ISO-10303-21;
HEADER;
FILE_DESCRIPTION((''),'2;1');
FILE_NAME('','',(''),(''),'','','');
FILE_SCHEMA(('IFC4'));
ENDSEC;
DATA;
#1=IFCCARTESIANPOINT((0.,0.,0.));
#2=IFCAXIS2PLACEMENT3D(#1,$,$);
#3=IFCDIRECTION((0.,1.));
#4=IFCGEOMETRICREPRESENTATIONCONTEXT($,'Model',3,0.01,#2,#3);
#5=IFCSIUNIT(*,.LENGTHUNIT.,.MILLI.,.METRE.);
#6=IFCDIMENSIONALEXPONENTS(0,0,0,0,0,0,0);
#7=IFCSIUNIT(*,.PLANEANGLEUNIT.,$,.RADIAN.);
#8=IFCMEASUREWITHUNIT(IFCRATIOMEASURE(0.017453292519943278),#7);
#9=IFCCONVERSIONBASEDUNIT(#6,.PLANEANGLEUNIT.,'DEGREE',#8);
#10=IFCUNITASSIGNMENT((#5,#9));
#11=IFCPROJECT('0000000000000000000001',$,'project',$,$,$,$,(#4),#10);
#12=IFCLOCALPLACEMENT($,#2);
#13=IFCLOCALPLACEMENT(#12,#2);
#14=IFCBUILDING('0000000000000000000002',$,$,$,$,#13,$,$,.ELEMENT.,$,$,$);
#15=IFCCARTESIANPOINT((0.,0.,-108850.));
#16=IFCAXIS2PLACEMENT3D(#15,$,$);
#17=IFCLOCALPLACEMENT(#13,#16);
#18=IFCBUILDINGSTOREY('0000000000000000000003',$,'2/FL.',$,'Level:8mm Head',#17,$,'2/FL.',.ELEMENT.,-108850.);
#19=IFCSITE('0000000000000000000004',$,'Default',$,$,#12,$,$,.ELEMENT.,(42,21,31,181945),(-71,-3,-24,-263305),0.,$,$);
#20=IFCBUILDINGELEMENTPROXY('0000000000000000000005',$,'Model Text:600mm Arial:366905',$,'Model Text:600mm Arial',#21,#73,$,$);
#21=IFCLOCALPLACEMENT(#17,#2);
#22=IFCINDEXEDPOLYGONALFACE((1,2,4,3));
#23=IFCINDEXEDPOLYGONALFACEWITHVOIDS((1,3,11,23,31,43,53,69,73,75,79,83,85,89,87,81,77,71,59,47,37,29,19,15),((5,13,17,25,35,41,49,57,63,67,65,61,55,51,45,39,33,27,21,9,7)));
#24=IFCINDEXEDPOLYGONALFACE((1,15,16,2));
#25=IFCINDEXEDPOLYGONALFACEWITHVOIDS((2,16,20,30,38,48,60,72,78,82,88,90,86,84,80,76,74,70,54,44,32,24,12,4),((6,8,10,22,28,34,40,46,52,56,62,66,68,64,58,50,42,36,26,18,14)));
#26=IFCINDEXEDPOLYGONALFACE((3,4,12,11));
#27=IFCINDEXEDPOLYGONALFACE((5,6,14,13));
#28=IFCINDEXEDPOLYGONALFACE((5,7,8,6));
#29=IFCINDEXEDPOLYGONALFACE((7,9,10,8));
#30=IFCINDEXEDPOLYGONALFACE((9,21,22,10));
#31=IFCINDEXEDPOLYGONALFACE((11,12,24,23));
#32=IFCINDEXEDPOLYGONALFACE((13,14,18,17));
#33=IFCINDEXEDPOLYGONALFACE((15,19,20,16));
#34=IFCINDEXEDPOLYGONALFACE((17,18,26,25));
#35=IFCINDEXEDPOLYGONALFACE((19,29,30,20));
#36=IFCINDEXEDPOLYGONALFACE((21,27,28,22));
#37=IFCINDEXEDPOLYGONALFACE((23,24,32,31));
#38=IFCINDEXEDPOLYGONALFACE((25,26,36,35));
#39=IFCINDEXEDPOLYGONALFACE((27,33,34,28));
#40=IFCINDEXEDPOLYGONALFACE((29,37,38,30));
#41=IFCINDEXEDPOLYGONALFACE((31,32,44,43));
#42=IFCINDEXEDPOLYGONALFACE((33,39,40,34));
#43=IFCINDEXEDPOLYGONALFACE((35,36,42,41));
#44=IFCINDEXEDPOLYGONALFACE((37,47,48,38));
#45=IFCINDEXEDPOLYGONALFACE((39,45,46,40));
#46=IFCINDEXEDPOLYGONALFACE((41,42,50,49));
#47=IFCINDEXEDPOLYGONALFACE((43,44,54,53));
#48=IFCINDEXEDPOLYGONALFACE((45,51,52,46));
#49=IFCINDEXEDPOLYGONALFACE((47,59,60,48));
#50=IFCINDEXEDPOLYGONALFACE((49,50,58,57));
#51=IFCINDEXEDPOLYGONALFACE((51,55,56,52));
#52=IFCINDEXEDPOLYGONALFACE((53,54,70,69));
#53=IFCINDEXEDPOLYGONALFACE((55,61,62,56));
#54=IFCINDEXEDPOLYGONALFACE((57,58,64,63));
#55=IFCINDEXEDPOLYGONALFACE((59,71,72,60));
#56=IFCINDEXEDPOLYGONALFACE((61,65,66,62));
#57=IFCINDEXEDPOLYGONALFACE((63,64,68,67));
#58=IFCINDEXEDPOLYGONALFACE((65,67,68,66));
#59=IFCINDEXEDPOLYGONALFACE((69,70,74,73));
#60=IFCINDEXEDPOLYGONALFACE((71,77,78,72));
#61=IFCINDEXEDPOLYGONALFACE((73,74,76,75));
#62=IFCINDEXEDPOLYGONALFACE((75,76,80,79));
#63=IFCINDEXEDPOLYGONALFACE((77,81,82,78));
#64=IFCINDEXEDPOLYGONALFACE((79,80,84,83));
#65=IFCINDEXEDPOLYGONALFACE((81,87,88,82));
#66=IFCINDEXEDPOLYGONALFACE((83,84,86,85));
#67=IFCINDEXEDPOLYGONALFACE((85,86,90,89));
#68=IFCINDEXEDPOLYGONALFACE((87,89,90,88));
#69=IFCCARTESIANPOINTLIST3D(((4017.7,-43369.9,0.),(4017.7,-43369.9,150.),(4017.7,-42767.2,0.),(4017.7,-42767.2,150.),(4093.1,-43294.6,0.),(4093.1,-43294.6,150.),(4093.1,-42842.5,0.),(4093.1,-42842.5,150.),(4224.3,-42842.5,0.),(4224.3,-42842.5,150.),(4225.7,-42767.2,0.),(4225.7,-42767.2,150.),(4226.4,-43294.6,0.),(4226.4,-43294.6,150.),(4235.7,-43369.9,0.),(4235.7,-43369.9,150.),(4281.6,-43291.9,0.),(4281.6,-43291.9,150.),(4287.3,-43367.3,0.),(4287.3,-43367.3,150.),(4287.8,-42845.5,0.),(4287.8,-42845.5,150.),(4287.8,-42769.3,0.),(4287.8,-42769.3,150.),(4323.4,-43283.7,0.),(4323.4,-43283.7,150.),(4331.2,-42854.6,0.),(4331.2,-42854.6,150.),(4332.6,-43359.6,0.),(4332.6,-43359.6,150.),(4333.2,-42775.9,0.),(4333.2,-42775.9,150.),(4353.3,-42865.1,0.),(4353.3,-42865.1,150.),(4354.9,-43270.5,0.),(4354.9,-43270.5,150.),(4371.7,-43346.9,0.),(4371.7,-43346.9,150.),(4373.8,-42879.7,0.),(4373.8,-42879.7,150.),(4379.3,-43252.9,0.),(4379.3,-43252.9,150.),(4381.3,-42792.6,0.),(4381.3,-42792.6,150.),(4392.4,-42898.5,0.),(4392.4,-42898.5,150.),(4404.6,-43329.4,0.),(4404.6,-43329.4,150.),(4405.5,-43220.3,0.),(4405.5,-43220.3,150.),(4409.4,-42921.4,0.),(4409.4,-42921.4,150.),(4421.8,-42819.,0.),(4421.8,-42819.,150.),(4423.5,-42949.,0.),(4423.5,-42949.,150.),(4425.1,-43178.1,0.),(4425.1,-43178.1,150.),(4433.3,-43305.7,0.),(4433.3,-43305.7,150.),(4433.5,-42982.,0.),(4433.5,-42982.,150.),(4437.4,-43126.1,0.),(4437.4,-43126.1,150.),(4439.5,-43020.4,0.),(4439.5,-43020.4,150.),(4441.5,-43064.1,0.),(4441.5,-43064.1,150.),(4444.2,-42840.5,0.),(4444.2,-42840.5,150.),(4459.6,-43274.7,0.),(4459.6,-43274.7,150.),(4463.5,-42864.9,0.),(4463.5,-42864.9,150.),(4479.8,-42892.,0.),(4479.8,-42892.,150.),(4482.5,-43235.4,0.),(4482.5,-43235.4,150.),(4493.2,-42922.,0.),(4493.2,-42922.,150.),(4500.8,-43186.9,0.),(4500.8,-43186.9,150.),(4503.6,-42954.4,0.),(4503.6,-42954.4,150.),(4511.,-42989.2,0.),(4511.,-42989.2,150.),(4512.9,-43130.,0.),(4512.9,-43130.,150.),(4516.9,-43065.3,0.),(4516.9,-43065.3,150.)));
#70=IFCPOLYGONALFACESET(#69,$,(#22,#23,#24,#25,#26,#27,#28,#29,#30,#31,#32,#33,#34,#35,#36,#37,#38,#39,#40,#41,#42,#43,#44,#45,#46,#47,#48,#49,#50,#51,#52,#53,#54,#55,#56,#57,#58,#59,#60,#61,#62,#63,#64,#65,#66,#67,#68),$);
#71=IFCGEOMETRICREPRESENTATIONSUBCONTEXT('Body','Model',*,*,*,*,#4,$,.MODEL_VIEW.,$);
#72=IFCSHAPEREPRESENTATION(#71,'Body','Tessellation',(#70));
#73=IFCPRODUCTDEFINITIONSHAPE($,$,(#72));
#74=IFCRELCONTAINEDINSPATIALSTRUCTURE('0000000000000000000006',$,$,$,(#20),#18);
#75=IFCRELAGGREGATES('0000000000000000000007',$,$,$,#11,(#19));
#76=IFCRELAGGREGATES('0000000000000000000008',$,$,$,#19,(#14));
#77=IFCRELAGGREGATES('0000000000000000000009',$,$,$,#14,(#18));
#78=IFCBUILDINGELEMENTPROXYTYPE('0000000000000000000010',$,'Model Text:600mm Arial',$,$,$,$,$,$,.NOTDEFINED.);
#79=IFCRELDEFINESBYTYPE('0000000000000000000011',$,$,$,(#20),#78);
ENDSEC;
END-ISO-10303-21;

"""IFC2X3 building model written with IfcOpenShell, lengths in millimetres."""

from ifc_helpers import new_model, entity, si_unit, converted_unit, direction, frame, origin, place, context, subcontext, project, spatial, polyline, outline, extrude, type_object, element, save


model = new_model("IFC2X3")

# Units and contexts
model_context = context("Model", 3, precision=0.01, world=origin(), true_north=direction((0.0, 1.0)))
body_context = subcontext(model_context, "Body", "Model", "MODEL_VIEW")
ifc_project = project(units=[si_unit("LENGTHUNIT", "METRE", prefix="MILLI"), converted_unit("PLANEANGLEUNIT", "DEGREE", entity("IfcRatioMeasure", 0.017453292519943278), si_unit("PLANEANGLEUNIT", "RADIAN"), dimensions=[0, 0, 0, 0, 0, 0, 0])], contexts=[model_context])

# Site, building, storey
site_placement = place(None, origin())
site = spatial("IfcSite", under=ifc_project, at=site_placement, Name="Default", CompositionType="ELEMENT", RefLatitude=(42, 21, 31, 181945), RefLongitude=(-71, -3, -24, -263305), RefElevation=0.0)
building_placement = place(site_placement, origin())
building = spatial("IfcBuilding", under=site, at=building_placement, CompositionType="ELEMENT")
storey_placement = place(building_placement, frame((0.0, 0.0, -108850.0)))
storey = spatial("IfcBuildingStorey", under=building, at=storey_placement, Name="2/FL.", ObjectType="Level:8mm Head", LongName="2/FL.", CompositionType="ELEMENT", Elevation=-108850.0)

# Building element proxy
building_element_proxy_type = type_object("IfcBuildingElementProxyType", Name="Model Text:600mm Arial", PredefinedType="NOTDEFINED")
proxy_1_placement = place(storey_placement, origin())
element("IfcBuildingElementProxy", 1, at=proxy_1_placement, inside=storey, type_object=building_element_proxy_type, Name="Model Text:600mm Arial:366905", ObjectType="Model Text:600mm Arial", context=body_context, shape_type="SweptSolid", body=[
    extrude(outline(polyline([(-362.2, -307.6), (-144.3, -307.6), (-92.7, -305.0), (-47.4, -297.3), (-8.3, -284.6), (24.7, -267.1), (53.4, -243.4), (79.7, -212.4), (102.6, -173.1), (120.9, -124.6), (132.9, -67.7), (137.0, -3.0), (131.0, 73.1), (123.6, 107.9), (113.3, 140.3), (99.9, 170.3), (83.6, 197.4), (64.2, 221.8), (41.9, 243.3), (1.4, 269.7), (-46.7, 286.4), (-92.1, 293.0), (-154.3, 295.1), (-362.2, 295.1), (-362.2, -307.6)]), holes=[polyline([(-286.8, -232.3), (-286.8, 219.8), (-155.6, 219.8), (-92.1, 216.8), (-48.8, 207.7), (-26.6, 197.2), (-6.2, 182.6), (12.5, 163.8), (29.5, 140.9), (43.5, 113.3), (53.6, 80.3), (59.6, 41.9), (61.6, -1.8), (57.5, -63.8), (45.2, -115.8), (25.5, -158.0), (-0.6, -190.6), (-25.0, -208.2), (-56.6, -221.4), (-98.4, -229.5), (-153.5, -232.3), (-286.8, -232.3)])]), frame((4379.9, -43062.3, 0.0)), (0.0, 0.0, 1.0), 150.0),
])

save(model, "model.ifc")
